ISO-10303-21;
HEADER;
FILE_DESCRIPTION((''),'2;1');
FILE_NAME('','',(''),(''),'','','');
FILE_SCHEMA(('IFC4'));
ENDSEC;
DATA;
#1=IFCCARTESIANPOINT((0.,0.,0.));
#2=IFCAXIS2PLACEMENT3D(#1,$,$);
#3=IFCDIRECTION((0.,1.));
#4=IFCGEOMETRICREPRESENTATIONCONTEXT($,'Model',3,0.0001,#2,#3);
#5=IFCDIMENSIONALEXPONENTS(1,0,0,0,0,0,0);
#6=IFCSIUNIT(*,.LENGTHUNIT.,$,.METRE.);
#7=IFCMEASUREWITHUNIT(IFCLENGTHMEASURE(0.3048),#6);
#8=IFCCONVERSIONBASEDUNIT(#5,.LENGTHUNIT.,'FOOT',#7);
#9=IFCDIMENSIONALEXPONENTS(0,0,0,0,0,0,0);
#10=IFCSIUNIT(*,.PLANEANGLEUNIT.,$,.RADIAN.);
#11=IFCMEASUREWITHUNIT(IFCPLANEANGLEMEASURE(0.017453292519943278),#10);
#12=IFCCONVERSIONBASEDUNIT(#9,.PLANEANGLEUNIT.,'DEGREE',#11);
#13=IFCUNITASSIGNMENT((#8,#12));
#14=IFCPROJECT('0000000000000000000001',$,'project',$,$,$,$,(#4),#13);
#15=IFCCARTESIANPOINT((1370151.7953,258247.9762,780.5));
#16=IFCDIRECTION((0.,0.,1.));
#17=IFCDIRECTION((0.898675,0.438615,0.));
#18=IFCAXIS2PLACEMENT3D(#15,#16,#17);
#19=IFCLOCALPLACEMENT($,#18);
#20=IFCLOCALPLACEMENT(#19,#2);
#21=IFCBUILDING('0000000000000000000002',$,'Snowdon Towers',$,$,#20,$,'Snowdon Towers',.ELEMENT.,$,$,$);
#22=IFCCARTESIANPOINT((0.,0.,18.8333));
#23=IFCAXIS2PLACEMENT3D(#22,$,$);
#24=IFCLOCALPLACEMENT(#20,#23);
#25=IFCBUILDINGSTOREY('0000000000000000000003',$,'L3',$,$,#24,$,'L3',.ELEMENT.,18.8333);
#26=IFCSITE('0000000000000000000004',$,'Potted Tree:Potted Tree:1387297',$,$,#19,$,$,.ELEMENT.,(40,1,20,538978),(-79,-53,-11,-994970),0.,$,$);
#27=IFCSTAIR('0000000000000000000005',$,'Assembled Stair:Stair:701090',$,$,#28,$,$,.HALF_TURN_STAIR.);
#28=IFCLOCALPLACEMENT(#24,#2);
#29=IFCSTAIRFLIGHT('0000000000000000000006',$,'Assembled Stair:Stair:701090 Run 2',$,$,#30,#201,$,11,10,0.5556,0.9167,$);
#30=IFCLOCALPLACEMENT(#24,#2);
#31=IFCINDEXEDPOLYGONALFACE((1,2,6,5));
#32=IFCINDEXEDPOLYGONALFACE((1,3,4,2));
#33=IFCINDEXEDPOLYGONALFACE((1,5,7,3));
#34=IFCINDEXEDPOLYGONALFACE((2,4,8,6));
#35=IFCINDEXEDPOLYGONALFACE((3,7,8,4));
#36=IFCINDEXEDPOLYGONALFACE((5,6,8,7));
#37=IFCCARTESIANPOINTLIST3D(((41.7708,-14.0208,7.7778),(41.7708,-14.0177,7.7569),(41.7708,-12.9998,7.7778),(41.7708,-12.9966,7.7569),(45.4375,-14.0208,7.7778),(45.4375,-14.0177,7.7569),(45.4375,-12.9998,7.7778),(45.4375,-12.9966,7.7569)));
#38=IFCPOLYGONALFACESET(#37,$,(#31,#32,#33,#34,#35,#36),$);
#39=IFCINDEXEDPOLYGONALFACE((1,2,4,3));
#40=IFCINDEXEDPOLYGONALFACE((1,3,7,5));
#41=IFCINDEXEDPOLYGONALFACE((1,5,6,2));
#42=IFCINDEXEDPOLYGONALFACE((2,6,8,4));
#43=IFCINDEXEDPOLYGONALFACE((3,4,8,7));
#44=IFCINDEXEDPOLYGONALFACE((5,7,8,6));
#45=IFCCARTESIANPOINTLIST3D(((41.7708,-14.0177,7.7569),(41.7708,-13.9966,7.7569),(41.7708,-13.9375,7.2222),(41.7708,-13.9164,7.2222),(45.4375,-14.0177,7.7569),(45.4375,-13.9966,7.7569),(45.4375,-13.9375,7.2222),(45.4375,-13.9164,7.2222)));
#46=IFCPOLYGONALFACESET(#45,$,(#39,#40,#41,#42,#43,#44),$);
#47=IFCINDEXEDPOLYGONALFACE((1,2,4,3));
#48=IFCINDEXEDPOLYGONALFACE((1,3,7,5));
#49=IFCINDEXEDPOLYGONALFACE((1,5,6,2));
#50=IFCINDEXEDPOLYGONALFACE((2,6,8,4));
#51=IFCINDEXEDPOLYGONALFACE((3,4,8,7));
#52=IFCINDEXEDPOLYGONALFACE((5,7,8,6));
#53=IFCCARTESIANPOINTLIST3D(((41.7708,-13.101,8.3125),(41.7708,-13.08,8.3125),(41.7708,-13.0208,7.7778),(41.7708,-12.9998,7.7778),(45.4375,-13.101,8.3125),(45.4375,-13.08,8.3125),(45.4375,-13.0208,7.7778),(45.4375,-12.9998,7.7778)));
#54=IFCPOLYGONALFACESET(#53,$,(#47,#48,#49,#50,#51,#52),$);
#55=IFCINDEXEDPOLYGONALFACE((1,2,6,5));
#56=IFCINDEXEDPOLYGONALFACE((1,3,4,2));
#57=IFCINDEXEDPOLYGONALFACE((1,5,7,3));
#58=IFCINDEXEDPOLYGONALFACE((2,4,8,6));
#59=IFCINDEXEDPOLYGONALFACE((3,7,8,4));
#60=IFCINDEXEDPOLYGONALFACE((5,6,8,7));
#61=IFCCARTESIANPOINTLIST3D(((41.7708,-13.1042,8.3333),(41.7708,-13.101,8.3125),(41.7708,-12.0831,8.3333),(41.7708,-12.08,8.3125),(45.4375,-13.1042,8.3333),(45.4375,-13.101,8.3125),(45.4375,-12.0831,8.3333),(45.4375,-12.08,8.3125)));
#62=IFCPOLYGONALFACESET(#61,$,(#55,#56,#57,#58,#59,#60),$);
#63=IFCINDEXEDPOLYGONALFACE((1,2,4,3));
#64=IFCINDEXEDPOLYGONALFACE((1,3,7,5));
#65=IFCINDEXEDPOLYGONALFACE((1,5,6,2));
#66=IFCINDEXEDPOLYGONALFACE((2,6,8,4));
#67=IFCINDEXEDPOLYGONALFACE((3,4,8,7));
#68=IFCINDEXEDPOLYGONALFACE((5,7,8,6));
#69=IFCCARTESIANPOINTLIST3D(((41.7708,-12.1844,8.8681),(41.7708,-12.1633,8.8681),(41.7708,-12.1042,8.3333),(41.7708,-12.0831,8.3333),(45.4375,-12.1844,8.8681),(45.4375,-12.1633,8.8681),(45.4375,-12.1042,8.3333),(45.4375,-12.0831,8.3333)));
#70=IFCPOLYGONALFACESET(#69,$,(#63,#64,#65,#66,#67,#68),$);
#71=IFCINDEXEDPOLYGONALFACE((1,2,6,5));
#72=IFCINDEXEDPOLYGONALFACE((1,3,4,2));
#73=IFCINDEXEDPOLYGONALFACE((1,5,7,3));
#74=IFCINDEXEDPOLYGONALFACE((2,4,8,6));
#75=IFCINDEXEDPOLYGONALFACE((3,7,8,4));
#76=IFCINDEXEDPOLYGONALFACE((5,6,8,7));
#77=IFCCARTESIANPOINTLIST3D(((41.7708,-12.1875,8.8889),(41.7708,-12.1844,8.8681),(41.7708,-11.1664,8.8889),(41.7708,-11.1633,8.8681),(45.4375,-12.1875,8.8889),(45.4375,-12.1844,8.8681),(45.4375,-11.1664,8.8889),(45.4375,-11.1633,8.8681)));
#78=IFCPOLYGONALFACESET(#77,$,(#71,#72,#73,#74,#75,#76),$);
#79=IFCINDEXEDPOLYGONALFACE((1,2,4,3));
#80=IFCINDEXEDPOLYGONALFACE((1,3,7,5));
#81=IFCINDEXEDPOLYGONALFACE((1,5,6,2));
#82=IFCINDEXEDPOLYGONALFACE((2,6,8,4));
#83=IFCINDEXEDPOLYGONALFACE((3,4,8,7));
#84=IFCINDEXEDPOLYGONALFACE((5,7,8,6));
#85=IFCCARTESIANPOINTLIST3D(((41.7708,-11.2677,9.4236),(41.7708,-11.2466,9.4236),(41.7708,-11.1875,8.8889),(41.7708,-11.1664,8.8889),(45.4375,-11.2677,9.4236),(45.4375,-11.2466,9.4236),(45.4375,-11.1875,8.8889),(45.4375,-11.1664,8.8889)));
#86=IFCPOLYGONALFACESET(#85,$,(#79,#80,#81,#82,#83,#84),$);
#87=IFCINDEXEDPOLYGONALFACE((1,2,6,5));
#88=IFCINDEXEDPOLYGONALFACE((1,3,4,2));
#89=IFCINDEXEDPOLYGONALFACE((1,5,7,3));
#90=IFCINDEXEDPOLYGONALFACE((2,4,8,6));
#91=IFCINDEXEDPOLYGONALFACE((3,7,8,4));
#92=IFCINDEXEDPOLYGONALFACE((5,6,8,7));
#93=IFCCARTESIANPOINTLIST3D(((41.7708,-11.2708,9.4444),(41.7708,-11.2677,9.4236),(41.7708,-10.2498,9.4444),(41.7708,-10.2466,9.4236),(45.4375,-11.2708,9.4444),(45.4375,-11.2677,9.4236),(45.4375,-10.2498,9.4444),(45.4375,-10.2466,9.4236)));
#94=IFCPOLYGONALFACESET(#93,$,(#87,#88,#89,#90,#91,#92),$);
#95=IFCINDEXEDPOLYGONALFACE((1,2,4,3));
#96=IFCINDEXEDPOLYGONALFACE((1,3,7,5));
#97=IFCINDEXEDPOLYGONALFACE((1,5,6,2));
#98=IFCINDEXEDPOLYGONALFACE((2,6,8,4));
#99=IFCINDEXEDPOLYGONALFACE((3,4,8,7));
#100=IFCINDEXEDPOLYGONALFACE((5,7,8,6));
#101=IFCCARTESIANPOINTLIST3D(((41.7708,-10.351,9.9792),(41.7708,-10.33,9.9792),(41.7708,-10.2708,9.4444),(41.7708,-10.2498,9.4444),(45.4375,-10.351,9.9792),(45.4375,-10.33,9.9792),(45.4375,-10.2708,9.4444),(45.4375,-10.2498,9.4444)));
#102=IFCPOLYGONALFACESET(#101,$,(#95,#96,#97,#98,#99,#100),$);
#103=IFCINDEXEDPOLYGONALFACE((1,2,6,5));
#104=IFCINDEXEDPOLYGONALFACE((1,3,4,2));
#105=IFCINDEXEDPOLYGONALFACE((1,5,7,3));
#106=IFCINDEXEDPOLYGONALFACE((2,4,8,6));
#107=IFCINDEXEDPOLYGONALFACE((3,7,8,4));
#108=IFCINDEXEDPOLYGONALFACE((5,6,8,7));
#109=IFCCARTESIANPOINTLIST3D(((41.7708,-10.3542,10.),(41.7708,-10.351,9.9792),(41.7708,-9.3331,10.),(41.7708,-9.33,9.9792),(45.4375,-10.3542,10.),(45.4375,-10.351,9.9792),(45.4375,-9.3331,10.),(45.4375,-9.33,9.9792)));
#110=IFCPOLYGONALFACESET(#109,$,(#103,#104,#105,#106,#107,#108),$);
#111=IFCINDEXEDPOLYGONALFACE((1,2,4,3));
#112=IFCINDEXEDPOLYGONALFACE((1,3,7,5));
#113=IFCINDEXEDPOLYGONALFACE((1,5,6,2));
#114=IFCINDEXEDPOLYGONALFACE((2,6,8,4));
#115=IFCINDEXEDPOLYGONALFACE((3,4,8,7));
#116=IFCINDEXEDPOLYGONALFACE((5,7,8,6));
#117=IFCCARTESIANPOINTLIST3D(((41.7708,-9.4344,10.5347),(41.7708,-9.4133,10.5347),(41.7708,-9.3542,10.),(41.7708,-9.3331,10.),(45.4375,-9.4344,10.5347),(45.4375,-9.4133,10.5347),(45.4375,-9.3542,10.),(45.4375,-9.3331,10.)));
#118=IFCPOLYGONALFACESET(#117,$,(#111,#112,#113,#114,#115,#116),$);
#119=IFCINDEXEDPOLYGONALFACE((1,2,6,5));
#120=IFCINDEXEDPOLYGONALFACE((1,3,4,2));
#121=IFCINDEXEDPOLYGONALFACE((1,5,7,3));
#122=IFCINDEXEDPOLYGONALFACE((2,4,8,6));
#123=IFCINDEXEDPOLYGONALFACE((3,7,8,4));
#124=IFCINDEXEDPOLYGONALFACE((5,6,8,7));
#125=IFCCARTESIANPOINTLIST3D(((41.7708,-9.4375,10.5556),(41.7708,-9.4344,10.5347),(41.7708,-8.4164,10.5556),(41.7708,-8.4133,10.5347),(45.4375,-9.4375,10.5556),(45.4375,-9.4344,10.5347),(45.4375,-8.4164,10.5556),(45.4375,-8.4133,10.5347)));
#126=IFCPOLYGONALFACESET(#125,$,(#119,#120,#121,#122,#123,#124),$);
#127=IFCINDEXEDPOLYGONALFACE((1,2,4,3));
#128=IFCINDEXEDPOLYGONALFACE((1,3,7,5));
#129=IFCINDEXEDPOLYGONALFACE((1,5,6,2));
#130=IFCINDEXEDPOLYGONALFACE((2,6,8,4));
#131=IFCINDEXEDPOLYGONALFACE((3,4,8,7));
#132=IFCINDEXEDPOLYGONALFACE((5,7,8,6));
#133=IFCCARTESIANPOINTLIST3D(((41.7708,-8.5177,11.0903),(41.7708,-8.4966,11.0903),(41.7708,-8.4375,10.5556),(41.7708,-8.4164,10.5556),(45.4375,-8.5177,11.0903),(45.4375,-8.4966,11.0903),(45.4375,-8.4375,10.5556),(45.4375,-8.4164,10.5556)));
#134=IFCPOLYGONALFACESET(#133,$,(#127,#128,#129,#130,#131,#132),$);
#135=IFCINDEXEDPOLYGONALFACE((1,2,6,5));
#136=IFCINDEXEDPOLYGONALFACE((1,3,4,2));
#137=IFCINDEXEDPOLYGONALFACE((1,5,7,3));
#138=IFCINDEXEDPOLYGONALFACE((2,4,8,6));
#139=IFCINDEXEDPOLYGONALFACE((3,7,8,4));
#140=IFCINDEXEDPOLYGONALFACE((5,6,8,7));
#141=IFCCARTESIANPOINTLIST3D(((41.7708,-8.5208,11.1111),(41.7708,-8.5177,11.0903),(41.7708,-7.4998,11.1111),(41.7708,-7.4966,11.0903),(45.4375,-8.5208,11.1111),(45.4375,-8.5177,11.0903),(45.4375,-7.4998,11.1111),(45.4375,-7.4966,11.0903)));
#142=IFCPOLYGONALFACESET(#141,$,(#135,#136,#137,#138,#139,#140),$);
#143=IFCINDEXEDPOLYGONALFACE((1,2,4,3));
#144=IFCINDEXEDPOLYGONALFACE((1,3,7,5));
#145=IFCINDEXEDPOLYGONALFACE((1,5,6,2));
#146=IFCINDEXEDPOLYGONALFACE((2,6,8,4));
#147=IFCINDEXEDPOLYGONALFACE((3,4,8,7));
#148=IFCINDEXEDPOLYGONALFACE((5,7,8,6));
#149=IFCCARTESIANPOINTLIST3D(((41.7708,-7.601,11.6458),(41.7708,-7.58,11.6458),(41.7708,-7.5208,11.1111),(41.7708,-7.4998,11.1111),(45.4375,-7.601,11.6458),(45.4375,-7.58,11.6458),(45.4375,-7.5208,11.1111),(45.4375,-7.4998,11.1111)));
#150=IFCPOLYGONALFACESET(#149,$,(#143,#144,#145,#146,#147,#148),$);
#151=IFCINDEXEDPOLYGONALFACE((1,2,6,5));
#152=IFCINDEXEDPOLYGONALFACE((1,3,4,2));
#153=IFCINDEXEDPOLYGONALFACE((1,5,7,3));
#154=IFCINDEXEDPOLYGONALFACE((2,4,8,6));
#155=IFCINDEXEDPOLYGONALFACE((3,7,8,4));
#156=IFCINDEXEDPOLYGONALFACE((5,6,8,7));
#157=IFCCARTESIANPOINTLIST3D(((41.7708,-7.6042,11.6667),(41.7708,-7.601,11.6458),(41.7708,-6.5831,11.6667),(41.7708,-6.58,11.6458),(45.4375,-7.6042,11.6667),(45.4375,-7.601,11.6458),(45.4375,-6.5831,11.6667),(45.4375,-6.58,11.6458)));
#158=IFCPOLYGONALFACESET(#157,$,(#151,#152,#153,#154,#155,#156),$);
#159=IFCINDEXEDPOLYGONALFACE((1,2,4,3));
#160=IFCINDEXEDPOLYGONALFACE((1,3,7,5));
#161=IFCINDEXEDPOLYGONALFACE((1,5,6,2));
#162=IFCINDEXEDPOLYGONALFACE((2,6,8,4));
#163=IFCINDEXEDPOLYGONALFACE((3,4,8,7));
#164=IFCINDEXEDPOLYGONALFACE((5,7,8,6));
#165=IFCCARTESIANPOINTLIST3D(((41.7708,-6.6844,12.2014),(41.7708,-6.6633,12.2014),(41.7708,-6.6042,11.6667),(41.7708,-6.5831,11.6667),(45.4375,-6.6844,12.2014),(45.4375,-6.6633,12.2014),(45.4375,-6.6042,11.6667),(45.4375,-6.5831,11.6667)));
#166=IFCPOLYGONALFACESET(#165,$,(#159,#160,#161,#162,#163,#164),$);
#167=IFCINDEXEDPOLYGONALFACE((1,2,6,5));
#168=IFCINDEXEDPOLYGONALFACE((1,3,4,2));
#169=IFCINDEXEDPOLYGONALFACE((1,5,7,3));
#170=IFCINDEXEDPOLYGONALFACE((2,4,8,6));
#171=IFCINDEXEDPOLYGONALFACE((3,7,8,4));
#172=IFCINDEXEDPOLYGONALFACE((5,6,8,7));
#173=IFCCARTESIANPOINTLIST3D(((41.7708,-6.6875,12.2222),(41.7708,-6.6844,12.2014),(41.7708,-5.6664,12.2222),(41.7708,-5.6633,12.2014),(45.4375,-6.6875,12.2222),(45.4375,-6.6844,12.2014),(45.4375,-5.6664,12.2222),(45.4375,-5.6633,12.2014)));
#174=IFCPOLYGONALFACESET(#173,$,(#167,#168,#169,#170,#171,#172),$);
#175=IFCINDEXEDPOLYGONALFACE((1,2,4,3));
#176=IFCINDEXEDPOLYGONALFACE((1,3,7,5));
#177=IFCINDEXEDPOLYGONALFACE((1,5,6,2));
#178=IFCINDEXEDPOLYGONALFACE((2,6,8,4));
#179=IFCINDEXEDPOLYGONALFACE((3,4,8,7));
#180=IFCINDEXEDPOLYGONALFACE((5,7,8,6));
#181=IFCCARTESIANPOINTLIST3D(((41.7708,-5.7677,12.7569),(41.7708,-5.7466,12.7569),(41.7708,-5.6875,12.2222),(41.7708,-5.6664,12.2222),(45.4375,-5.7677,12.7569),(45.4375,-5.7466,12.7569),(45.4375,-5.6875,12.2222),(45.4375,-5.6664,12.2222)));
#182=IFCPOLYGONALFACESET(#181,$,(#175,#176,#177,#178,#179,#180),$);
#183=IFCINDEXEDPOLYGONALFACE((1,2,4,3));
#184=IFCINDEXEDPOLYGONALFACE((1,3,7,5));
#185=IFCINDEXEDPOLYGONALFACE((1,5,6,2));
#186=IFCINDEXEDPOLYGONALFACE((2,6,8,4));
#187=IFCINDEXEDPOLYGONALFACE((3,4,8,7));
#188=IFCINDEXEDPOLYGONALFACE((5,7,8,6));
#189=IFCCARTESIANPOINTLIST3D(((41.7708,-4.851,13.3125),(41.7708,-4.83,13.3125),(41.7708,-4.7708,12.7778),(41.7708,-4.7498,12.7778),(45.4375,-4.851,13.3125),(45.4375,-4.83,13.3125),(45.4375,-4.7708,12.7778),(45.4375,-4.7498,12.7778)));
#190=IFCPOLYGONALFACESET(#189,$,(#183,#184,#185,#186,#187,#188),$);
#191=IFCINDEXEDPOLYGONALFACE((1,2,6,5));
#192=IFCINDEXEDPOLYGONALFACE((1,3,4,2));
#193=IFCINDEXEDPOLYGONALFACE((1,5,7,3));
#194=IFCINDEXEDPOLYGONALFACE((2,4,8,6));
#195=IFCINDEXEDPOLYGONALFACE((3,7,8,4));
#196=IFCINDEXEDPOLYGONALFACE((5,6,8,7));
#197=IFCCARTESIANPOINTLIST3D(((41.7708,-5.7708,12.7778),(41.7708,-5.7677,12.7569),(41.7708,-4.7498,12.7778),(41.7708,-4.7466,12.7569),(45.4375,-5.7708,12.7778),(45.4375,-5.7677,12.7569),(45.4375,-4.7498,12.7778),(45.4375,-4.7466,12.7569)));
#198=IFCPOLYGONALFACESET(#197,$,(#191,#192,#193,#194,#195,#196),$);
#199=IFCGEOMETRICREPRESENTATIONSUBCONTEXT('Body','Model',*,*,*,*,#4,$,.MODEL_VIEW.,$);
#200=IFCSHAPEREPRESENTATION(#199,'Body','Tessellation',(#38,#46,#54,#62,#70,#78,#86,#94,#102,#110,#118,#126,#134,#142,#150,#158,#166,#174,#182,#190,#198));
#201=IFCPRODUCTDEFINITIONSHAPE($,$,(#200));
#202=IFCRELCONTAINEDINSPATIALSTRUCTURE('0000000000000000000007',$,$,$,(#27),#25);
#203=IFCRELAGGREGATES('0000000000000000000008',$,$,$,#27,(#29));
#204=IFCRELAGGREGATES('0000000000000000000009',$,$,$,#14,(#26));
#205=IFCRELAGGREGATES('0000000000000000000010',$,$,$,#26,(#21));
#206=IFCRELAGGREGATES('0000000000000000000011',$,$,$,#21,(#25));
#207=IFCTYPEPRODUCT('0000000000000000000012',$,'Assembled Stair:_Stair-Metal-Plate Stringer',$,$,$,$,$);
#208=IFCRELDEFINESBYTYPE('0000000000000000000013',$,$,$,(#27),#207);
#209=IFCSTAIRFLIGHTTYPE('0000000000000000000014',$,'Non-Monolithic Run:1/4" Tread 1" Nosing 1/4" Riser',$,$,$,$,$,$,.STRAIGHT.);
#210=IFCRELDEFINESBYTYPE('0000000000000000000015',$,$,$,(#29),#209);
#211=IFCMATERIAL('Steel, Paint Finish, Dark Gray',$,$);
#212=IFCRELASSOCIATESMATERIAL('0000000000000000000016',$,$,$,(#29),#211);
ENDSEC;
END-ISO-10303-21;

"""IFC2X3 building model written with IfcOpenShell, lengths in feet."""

from ifc_helpers import new_model, entity, si_unit, converted_unit, direction, frame, origin, place, context, subcontext, project, spatial, polyline, outline, extrude, material, type_object, element, aggregate, save


model = new_model("IFC2X3")

# Units and contexts
model_context = context("Model", 3, precision=0.0001, world=origin(), true_north=direction((0.0, 1.0)))
body_context = subcontext(model_context, "Body", "Model", "MODEL_VIEW")
ifc_project = project(units=[converted_unit("LENGTHUNIT", "FOOT", entity("IfcLengthMeasure", 0.3048), si_unit("LENGTHUNIT", "METRE"), dimensions=[1, 0, 0, 0, 0, 0, 0]), converted_unit("PLANEANGLEUNIT", "DEGREE", entity("IfcPlaneAngleMeasure", 0.017453292519943278), si_unit("PLANEANGLEUNIT", "RADIAN"), dimensions=[0, 0, 0, 0, 0, 0, 0])], contexts=[model_context])

# Site, building, storey
site_placement = place(None, frame((1370151.7953, 258247.9762, 780.5), z_axis=(0.0, 0.0, 1.0), x_axis=(0.898675, 0.438615, 0.0)))
site = spatial("IfcSite", under=ifc_project, at=site_placement, Name="Potted Tree:Potted Tree:1387297", CompositionType="ELEMENT", RefLatitude=(40, 1, 20, 538978), RefLongitude=(-79, -53, -11, -994970), RefElevation=0.0)
building_placement = place(site_placement, origin())
building = spatial("IfcBuilding", under=site, at=building_placement, Name="Snowdon Towers", LongName="Snowdon Towers", CompositionType="ELEMENT")
storey_placement = place(building_placement, frame((0.0, 0.0, 18.8333)))
storey = spatial("IfcBuildingStorey", under=building, at=storey_placement, Name="L3", LongName="L3", CompositionType="ELEMENT", Elevation=18.8333)

# Stair
type_product = type_object("IfcTypeProduct", Name="Assembled Stair:_Stair-Metal-Plate Stringer")
ifc_material_1 = material(Name="Steel, Paint Finish, Dark Gray")
stair_1_placement = place(storey_placement, origin())
stair_1 = element("IfcStair", 1, at=stair_1_placement, inside=storey, type_object=type_product, Name="Assembled Stair:Stair:701090", ShapeType="HALF_TURN_STAIR")

# Stair flight
stair_flight_type = type_object("IfcStairFlightType", Name="Non-Monolithic Run:1/4\" Tread 1\" Nosing 1/4\" Riser", PredefinedType="STRAIGHT")
stair_flight_1_placement = place(stair_1_placement, origin())
stair_flight_1 = element("IfcStairFlight", 2, at=stair_flight_1_placement, type_object=stair_flight_type, material=ifc_material_1, Name="Assembled Stair:Stair:701090 Run 2", NumberOfRiser=11, NumberOfTreads=10, RiserHeight=0.5556, TreadLength=0.9167, context=body_context, shape_type="SweptSolid", body=[
    extrude(outline(polyline([(-0.0863, -0.5049), (-0.0652, -0.5049), (0.0863, 0.5049), (0.0652, 0.5049), (-0.0863, -0.5049)])), frame((41.7708, -13.5087, 7.7674), z_axis=(1.0, 0.0, 0.0), x_axis=(0.0, 0.14834, -0.988936)), (0.0, 0.0, 1.0), 3.6667),
    extrude(outline(polyline([(-0.2719, -0.0104), (0.2688, -0.0104), (0.2719, 0.0104), (-0.2688, 0.0104), (-0.2719, -0.0104)])), frame((41.7708, -13.9671, 7.4896), z_axis=(1.0, 0.0, 0.0), x_axis=(0.0, 0.14834, -0.988936)), (0.0, 0.0, 1.0), 3.6667),
    extrude(outline(polyline([(-0.2719, -0.0104), (0.2688, -0.0104), (0.2719, 0.0104), (-0.2688, 0.0104), (-0.2719, -0.0104)])), frame((41.7708, -13.0504, 8.0451), z_axis=(1.0, 0.0, 0.0), x_axis=(0.0, 0.14834, -0.988936)), (0.0, 0.0, 1.0), 3.6667),
    extrude(outline(polyline([(-0.0863, -0.5049), (-0.0652, -0.5049), (0.0863, 0.5049), (0.0652, 0.5049), (-0.0863, -0.5049)])), frame((41.7708, -12.5921, 8.3229), z_axis=(1.0, 0.0, 0.0), x_axis=(0.0, 0.14834, -0.988936)), (0.0, 0.0, 1.0), 3.6667),
    extrude(outline(polyline([(-0.2719, -0.0104), (0.2688, -0.0104), (0.2719, 0.0104), (-0.2688, 0.0104), (-0.2719, -0.0104)])), frame((41.7708, -12.1337, 8.6007), z_axis=(1.0, 0.0, 0.0), x_axis=(0.0, 0.14834, -0.988936)), (0.0, 0.0, 1.0), 3.6667),
    extrude(outline(polyline([(-0.0863, -0.5049), (-0.0652, -0.5049), (0.0863, 0.5049), (0.0652, 0.5049), (-0.0863, -0.5049)])), frame((41.7708, -11.6754, 8.8785), z_axis=(1.0, 0.0, 0.0), x_axis=(0.0, 0.14834, -0.988936)), (0.0, 0.0, 1.0), 3.6667),
    extrude(outline(polyline([(-0.2719, -0.0104), (0.2688, -0.0104), (0.2719, 0.0104), (-0.2688, 0.0104), (-0.2719, -0.0104)])), frame((41.7708, -11.2171, 9.1563), z_axis=(1.0, 0.0, 0.0), x_axis=(0.0, 0.14834, -0.988936)), (0.0, 0.0, 1.0), 3.6667),
    extrude(outline(polyline([(-0.0863, -0.5049), (-0.0652, -0.5049), (0.0863, 0.5049), (0.0652, 0.5049), (-0.0863, -0.5049)])), frame((41.7708, -10.7587, 9.434), z_axis=(1.0, 0.0, 0.0), x_axis=(0.0, 0.14834, -0.988936)), (0.0, 0.0, 1.0), 3.6667),
    extrude(outline(polyline([(-0.2719, -0.0104), (0.2688, -0.0104), (0.2719, 0.0104), (-0.2688, 0.0104), (-0.2719, -0.0104)])), frame((41.7708, -10.3004, 9.7118), z_axis=(1.0, 0.0, 0.0), x_axis=(0.0, 0.14834, -0.988936)), (0.0, 0.0, 1.0), 3.6667),
    extrude(outline(polyline([(-0.0863, -0.5049), (-0.0652, -0.5049), (0.0863, 0.5049), (0.0652, 0.5049), (-0.0863, -0.5049)])), frame((41.7708, -9.8421, 9.9896), z_axis=(1.0, 0.0, 0.0), x_axis=(0.0, 0.14834, -0.988936)), (0.0, 0.0, 1.0), 3.6667),
    extrude(outline(polyline([(-0.2719, -0.0104), (0.2688, -0.0104), (0.2719, 0.0104), (-0.2688, 0.0104), (-0.2719, -0.0104)])), frame((41.7708, -9.3837, 10.2674), z_axis=(1.0, 0.0, 0.0), x_axis=(0.0, 0.14834, -0.988936)), (0.0, 0.0, 1.0), 3.6667),
    extrude(outline(polyline([(-0.0863, -0.5049), (-0.0652, -0.5049), (0.0863, 0.5049), (0.0652, 0.5049), (-0.0863, -0.5049)])), frame((41.7708, -8.9254, 10.5451), z_axis=(1.0, 0.0, 0.0), x_axis=(0.0, 0.14834, -0.988936)), (0.0, 0.0, 1.0), 3.6667),
    extrude(outline(polyline([(-0.2719, -0.0104), (0.2688, -0.0104), (0.2719, 0.0104), (-0.2688, 0.0104), (-0.2719, -0.0104)])), frame((41.7708, -8.4671, 10.8229), z_axis=(1.0, 0.0, 0.0), x_axis=(0.0, 0.14834, -0.988936)), (0.0, 0.0, 1.0), 3.6667),
    extrude(outline(polyline([(-0.0863, -0.5049), (-0.0652, -0.5049), (0.0863, 0.5049), (0.0652, 0.5049), (-0.0863, -0.5049)])), frame((41.7708, -8.0087, 11.1007), z_axis=(1.0, 0.0, 0.0), x_axis=(0.0, 0.14834, -0.988936)), (0.0, 0.0, 1.0), 3.6667),
    extrude(outline(polyline([(-0.2719, -0.0104), (0.2688, -0.0104), (0.2719, 0.0104), (-0.2688, 0.0104), (-0.2719, -0.0104)])), frame((41.7708, -7.5504, 11.3785), z_axis=(1.0, 0.0, 0.0), x_axis=(0.0, 0.14834, -0.988936)), (0.0, 0.0, 1.0), 3.6667),
    extrude(outline(polyline([(-0.0863, -0.5049), (-0.0652, -0.5049), (0.0863, 0.5049), (0.0652, 0.5049), (-0.0863, -0.5049)])), frame((41.7708, -7.0921, 11.6563), z_axis=(1.0, 0.0, 0.0), x_axis=(0.0, 0.14834, -0.988936)), (0.0, 0.0, 1.0), 3.6667),
    extrude(outline(polyline([(-0.2719, -0.0104), (0.2688, -0.0104), (0.2719, 0.0104), (-0.2688, 0.0104), (-0.2719, -0.0104)])), frame((41.7708, -6.6337, 11.934), z_axis=(1.0, 0.0, 0.0), x_axis=(0.0, 0.14834, -0.988936)), (0.0, 0.0, 1.0), 3.6667),
    extrude(outline(polyline([(-0.0863, -0.5049), (-0.0652, -0.5049), (0.0863, 0.5049), (0.0652, 0.5049), (-0.0863, -0.5049)])), frame((41.7708, -6.1754, 12.2118), z_axis=(1.0, 0.0, 0.0), x_axis=(0.0, 0.14834, -0.988936)), (0.0, 0.0, 1.0), 3.6667),
    extrude(outline(polyline([(-0.2719, -0.0104), (0.2688, -0.0104), (0.2719, 0.0104), (-0.2688, 0.0104), (-0.2719, -0.0104)])), frame((41.7708, -5.7171, 12.4896), z_axis=(1.0, 0.0, 0.0), x_axis=(0.0, 0.14834, -0.988936)), (0.0, 0.0, 1.0), 3.6667),
    extrude(outline(polyline([(-0.2719, -0.0104), (0.2688, -0.0104), (0.2719, 0.0104), (-0.2688, 0.0104), (-0.2719, -0.0104)])), frame((41.7708, -4.8004, 13.0451), z_axis=(1.0, 0.0, 0.0), x_axis=(0.0, 0.14834, -0.988936)), (0.0, 0.0, 1.0), 3.6667),
    extrude(outline(polyline([(-0.0863, -0.5049), (-0.0652, -0.5049), (0.0863, 0.5049), (0.0652, 0.5049), (-0.0863, -0.5049)])), frame((41.7708, -5.2587, 12.7674), z_axis=(1.0, 0.0, 0.0), x_axis=(0.0, 0.14834, -0.988936)), (0.0, 0.0, 1.0), 3.6667),
])
aggregate(stair_1, [stair_flight_1])

save(model, "model.ifc")
